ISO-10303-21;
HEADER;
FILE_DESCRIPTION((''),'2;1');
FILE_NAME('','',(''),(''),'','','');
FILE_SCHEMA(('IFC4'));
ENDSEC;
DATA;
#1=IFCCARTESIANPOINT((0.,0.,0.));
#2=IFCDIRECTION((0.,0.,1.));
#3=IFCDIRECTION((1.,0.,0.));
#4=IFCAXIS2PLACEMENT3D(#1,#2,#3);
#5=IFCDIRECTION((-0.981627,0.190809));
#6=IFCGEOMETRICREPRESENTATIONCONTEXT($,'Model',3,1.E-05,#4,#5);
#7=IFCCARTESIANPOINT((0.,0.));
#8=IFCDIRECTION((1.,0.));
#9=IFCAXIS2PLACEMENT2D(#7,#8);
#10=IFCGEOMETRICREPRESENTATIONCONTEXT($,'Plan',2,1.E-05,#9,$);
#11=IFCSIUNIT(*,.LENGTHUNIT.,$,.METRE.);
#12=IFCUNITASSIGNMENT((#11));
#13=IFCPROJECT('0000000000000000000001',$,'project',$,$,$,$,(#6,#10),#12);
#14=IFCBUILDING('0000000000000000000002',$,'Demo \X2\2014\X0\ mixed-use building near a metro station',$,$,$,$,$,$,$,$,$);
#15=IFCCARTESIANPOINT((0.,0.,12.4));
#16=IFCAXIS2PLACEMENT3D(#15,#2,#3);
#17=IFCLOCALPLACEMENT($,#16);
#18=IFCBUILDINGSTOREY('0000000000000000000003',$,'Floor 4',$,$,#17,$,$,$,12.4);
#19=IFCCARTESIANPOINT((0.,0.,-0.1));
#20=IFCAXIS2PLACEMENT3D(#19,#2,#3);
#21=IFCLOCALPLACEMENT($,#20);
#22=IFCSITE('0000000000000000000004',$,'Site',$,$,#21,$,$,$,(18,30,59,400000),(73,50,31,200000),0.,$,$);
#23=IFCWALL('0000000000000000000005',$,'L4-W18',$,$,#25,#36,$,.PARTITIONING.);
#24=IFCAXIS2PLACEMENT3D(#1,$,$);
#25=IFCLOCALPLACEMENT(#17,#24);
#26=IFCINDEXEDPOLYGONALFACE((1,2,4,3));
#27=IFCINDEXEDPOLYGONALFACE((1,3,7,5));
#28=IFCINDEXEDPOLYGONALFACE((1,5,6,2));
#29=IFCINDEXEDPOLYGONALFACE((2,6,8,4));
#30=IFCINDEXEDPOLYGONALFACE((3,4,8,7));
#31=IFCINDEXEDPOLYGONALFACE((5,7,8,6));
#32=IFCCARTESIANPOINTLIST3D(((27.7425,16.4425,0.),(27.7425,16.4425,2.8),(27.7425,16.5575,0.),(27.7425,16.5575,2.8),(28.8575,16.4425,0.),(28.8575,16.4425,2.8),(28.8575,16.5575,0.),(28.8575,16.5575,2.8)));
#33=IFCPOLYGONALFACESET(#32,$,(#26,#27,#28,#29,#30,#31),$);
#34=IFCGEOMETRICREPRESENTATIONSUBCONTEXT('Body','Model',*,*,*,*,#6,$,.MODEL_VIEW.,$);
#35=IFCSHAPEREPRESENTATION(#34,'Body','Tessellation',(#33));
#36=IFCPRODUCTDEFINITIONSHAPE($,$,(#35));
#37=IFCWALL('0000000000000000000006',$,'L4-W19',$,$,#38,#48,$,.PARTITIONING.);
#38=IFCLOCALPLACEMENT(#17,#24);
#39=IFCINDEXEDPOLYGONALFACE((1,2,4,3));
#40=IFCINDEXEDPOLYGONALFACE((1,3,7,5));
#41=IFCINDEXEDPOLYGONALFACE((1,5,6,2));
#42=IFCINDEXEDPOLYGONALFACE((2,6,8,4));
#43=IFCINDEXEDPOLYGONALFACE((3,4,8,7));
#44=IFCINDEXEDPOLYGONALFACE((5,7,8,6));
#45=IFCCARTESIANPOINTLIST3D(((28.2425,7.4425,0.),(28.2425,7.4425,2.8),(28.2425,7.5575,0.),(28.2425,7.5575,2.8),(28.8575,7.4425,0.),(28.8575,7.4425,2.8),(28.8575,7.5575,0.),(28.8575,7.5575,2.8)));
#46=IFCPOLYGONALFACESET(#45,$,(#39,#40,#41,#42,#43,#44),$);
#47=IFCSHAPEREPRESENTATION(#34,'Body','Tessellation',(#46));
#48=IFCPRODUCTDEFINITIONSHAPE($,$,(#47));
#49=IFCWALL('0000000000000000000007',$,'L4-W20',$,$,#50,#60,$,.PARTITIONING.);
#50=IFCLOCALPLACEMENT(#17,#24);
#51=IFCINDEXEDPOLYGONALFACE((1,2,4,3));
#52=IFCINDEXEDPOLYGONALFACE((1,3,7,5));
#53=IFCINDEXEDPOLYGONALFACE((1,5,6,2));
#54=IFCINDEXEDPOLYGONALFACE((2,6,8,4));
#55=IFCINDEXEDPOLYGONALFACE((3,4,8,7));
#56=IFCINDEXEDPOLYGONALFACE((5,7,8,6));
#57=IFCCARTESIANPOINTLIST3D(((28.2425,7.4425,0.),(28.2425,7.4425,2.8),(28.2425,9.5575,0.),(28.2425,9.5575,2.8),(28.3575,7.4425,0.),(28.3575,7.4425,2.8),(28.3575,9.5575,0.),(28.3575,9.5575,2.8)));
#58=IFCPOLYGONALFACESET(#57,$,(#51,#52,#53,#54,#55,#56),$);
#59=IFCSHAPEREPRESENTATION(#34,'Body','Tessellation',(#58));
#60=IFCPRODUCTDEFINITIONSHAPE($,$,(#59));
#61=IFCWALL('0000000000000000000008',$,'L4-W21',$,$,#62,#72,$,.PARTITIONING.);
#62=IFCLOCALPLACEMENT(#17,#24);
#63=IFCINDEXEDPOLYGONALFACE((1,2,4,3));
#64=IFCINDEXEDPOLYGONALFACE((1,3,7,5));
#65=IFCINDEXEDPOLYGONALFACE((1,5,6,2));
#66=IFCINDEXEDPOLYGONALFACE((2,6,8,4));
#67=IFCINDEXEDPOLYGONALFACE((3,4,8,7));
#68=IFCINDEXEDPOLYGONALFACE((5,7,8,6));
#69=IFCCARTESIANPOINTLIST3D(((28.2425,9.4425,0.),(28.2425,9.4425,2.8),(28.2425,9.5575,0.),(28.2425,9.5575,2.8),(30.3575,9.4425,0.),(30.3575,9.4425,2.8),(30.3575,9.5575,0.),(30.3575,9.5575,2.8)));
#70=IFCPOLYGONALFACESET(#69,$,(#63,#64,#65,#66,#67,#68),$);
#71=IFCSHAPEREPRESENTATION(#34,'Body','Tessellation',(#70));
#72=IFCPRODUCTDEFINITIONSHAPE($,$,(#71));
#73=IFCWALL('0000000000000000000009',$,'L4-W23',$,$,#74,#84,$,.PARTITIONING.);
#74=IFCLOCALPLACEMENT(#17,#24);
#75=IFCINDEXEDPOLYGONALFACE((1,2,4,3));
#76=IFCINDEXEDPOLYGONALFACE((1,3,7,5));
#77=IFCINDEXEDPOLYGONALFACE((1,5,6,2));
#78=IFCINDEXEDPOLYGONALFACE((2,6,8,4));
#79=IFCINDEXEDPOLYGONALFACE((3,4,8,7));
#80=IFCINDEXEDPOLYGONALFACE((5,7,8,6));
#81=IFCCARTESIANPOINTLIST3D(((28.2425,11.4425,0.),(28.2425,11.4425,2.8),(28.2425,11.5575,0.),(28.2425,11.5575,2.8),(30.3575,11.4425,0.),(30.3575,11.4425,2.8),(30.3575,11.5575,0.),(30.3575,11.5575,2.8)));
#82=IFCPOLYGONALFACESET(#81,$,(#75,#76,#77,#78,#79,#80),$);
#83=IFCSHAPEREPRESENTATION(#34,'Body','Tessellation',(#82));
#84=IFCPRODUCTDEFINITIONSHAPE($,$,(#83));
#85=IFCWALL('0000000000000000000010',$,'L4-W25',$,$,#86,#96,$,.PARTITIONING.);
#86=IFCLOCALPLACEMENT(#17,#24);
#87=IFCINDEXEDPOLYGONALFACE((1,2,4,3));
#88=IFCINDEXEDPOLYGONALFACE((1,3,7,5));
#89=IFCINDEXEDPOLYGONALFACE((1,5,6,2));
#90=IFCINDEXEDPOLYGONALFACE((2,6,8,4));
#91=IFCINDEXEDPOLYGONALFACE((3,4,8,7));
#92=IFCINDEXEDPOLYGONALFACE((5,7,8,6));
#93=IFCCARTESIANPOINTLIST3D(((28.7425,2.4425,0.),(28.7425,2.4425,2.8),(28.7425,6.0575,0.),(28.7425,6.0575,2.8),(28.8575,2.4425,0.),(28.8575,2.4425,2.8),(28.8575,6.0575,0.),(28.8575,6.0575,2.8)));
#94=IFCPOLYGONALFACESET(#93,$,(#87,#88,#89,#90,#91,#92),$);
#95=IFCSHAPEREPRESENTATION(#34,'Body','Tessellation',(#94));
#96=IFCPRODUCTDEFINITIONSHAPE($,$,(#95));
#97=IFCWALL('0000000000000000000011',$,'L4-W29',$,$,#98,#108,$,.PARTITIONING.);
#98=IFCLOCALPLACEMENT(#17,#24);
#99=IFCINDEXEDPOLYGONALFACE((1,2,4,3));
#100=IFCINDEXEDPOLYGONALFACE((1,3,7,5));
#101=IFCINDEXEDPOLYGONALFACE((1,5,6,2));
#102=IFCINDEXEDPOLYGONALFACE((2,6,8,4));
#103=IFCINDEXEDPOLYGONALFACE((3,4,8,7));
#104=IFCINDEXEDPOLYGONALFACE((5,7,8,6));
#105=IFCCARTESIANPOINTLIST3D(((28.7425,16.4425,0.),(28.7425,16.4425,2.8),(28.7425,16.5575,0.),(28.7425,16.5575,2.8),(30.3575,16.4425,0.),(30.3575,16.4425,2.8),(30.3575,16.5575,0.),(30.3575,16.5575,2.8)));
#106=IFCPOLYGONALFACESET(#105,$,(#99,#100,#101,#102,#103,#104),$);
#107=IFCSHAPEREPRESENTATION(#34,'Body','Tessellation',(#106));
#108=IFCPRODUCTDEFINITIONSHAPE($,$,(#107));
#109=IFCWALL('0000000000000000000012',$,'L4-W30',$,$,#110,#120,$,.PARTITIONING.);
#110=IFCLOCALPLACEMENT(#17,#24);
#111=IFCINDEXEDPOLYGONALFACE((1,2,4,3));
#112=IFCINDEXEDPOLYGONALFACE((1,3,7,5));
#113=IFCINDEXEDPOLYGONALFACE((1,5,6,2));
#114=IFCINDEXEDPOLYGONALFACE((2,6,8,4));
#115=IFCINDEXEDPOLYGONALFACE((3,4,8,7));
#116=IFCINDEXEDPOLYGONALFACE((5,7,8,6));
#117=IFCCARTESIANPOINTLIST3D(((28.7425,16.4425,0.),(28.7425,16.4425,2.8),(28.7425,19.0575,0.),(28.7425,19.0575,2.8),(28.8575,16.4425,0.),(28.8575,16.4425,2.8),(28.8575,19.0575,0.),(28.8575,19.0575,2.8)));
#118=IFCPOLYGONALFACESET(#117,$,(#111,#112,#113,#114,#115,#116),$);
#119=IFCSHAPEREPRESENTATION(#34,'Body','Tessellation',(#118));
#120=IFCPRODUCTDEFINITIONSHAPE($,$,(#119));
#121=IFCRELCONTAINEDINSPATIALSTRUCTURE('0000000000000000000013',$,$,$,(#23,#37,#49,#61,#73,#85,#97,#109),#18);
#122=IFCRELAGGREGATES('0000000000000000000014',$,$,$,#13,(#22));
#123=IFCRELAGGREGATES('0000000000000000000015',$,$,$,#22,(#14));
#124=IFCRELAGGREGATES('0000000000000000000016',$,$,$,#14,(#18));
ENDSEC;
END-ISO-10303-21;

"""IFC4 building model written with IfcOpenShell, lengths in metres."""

from ifc_helpers import new_model, si_unit, direction, frame, origin_with_axes, origin_2d_with_axis, place, context, subcontext, project, spatial, line, indexed_curve, outline, extrude, element, save


model = new_model("IFC4")

# Units and contexts
model_context = context("Model", 3, precision=1e-05, world=origin_with_axes(), true_north=direction((-0.981627, 0.190809)))
plan_context = context("Plan", 2, precision=1e-05, world=origin_2d_with_axis())
body_context = subcontext(model_context, "Body", "Model", "MODEL_VIEW")
ifc_project = project(units=[si_unit("LENGTHUNIT", "METRE")], contexts=[model_context, plan_context])

# Site, building, storey
site_placement = place(None, frame((0.0, 0.0, -0.1), z_axis=(0.0, 0.0, 1.0), x_axis=(1.0, 0.0, 0.0)))
site = spatial("IfcSite", under=ifc_project, at=site_placement, Name="Site", RefLatitude=(18, 30, 59, 400000), RefLongitude=(73, 50, 31, 200000), RefElevation=0.0)
building = spatial("IfcBuilding", under=site, Name="Demo — mixed-use building near a metro station")
storey_placement = place(None, frame((0.0, 0.0, 12.4), z_axis=(0.0, 0.0, 1.0), x_axis=(1.0, 0.0, 0.0)))
storey = spatial("IfcBuildingStorey", under=building, at=storey_placement, Name="Floor 4", Elevation=12.4)

# Walls
wall_1_placement = place(storey_placement, frame((0.0, 0.0, -12.4), z_axis=(0.0, 0.0, 1.0), x_axis=(1.0, 0.0, 0.0)))
element("IfcWall", 1, at=wall_1_placement, inside=storey, Name="L4-W18", PredefinedType="PARTITIONING", context=body_context, shape_type="SweptSolid", body=[
    extrude(outline(indexed_curve([(28.8575, 16.4425), (27.7425, 16.4425), (27.7425, 16.5575), (28.8575, 16.5575)], segments=[line(1, 2, 3, 4, 1)])), frame((0.0, 0.0, 12.4), z_axis=(0.0, 0.0, 1.0), x_axis=(1.0, 0.0, 0.0)), (0.0, 0.0, 1.0), 2.8),
])
wall_2_placement = place(storey_placement, frame((0.0, 0.0, -12.4), z_axis=(0.0, 0.0, 1.0), x_axis=(1.0, 0.0, 0.0)))
element("IfcWall", 2, at=wall_2_placement, inside=storey, Name="L4-W19", PredefinedType="PARTITIONING", context=body_context, shape_type="SweptSolid", body=[
    extrude(outline(indexed_curve([(28.8575, 7.4425), (28.2425, 7.4425), (28.2425, 7.5575), (28.8575, 7.5575)], segments=[line(1, 2, 3, 4, 1)])), frame((0.0, 0.0, 12.4), z_axis=(0.0, 0.0, 1.0), x_axis=(1.0, 0.0, 0.0)), (0.0, 0.0, 1.0), 2.8),
])
wall_3_placement = place(storey_placement, frame((0.0, 0.0, -12.4), z_axis=(0.0, 0.0, 1.0), x_axis=(1.0, 0.0, 0.0)))
element("IfcWall", 3, at=wall_3_placement, inside=storey, Name="L4-W20", PredefinedType="PARTITIONING", context=body_context, shape_type="SweptSolid", body=[
    extrude(outline(indexed_curve([(28.2425, 7.4425), (28.2425, 9.5575), (28.3575, 9.5575), (28.3575, 7.4425)], segments=[line(1, 2, 3, 4, 1)])), frame((0.0, 0.0, 12.4), z_axis=(0.0, 0.0, 1.0), x_axis=(1.0, 0.0, 0.0)), (0.0, 0.0, 1.0), 2.8),
])
wall_4_placement = place(storey_placement, frame((0.0, 0.0, -12.4), z_axis=(0.0, 0.0, 1.0), x_axis=(1.0, 0.0, 0.0)))
element("IfcWall", 4, at=wall_4_placement, inside=storey, Name="L4-W21", PredefinedType="PARTITIONING", context=body_context, shape_type="SweptSolid", body=[
    extrude(outline(indexed_curve([(30.3575, 9.4425), (28.2425, 9.4425), (28.2425, 9.5575), (30.3575, 9.5575)], segments=[line(1, 2, 3, 4, 1)])), frame((0.0, 0.0, 12.4), z_axis=(0.0, 0.0, 1.0), x_axis=(1.0, 0.0, 0.0)), (0.0, 0.0, 1.0), 2.8),
])

# Wall
wall_5_placement = place(storey_placement, frame((0.0, 0.0, -12.4), z_axis=(0.0, 0.0, 1.0), x_axis=(1.0, 0.0, 0.0)))
element("IfcWall", 5, at=wall_5_placement, inside=storey, Name="L4-W23", PredefinedType="PARTITIONING", context=body_context, shape_type="SweptSolid", body=[
    extrude(outline(indexed_curve([(28.2425, 11.5575), (30.3575, 11.5575), (30.3575, 11.4425), (28.2425, 11.4425)], segments=[line(1, 2, 3, 4, 1)])), frame((0.0, 0.0, 12.4), z_axis=(0.0, 0.0, 1.0), x_axis=(1.0, 0.0, 0.0)), (0.0, 0.0, 1.0), 2.8),
])

# Wall
wall_6_placement = place(storey_placement, frame((0.0, 0.0, -12.4), z_axis=(0.0, 0.0, 1.0), x_axis=(1.0, 0.0, 0.0)))
element("IfcWall", 6, at=wall_6_placement, inside=storey, Name="L4-W25", PredefinedType="PARTITIONING", context=body_context, shape_type="SweptSolid", body=[
    extrude(outline(indexed_curve([(28.7425, 2.4425), (28.7425, 6.0575), (28.8575, 6.0575), (28.8575, 2.4425)], segments=[line(1, 2, 3, 4, 1)])), frame((0.0, 0.0, 12.4), z_axis=(0.0, 0.0, 1.0), x_axis=(1.0, 0.0, 0.0)), (0.0, 0.0, 1.0), 2.8),
])

# Walls
wall_7_placement = place(storey_placement, frame((0.0, 0.0, -12.4), z_axis=(0.0, 0.0, 1.0), x_axis=(1.0, 0.0, 0.0)))
element("IfcWall", 7, at=wall_7_placement, inside=storey, Name="L4-W29", PredefinedType="PARTITIONING", context=body_context, shape_type="SweptSolid", body=[
    extrude(outline(indexed_curve([(30.3575, 16.4425), (28.7425, 16.4425), (28.7425, 16.5575), (30.3575, 16.5575)], segments=[line(1, 2, 3, 4, 1)])), frame((0.0, 0.0, 12.4), z_axis=(0.0, 0.0, 1.0), x_axis=(1.0, 0.0, 0.0)), (0.0, 0.0, 1.0), 2.8),
])
wall_8_placement = place(storey_placement, frame((0.0, 0.0, -12.4), z_axis=(0.0, 0.0, 1.0), x_axis=(1.0, 0.0, 0.0)))
element("IfcWall", 8, at=wall_8_placement, inside=storey, Name="L4-W30", PredefinedType="PARTITIONING", context=body_context, shape_type="SweptSolid", body=[
    extrude(outline(indexed_curve([(28.7425, 16.4425), (28.7425, 19.0575), (28.8575, 19.0575), (28.8575, 16.4425)], segments=[line(1, 2, 3, 4, 1)])), frame((0.0, 0.0, 12.4), z_axis=(0.0, 0.0, 1.0), x_axis=(1.0, 0.0, 0.0)), (0.0, 0.0, 1.0), 2.8),
])

save(model, "model.ifc")
